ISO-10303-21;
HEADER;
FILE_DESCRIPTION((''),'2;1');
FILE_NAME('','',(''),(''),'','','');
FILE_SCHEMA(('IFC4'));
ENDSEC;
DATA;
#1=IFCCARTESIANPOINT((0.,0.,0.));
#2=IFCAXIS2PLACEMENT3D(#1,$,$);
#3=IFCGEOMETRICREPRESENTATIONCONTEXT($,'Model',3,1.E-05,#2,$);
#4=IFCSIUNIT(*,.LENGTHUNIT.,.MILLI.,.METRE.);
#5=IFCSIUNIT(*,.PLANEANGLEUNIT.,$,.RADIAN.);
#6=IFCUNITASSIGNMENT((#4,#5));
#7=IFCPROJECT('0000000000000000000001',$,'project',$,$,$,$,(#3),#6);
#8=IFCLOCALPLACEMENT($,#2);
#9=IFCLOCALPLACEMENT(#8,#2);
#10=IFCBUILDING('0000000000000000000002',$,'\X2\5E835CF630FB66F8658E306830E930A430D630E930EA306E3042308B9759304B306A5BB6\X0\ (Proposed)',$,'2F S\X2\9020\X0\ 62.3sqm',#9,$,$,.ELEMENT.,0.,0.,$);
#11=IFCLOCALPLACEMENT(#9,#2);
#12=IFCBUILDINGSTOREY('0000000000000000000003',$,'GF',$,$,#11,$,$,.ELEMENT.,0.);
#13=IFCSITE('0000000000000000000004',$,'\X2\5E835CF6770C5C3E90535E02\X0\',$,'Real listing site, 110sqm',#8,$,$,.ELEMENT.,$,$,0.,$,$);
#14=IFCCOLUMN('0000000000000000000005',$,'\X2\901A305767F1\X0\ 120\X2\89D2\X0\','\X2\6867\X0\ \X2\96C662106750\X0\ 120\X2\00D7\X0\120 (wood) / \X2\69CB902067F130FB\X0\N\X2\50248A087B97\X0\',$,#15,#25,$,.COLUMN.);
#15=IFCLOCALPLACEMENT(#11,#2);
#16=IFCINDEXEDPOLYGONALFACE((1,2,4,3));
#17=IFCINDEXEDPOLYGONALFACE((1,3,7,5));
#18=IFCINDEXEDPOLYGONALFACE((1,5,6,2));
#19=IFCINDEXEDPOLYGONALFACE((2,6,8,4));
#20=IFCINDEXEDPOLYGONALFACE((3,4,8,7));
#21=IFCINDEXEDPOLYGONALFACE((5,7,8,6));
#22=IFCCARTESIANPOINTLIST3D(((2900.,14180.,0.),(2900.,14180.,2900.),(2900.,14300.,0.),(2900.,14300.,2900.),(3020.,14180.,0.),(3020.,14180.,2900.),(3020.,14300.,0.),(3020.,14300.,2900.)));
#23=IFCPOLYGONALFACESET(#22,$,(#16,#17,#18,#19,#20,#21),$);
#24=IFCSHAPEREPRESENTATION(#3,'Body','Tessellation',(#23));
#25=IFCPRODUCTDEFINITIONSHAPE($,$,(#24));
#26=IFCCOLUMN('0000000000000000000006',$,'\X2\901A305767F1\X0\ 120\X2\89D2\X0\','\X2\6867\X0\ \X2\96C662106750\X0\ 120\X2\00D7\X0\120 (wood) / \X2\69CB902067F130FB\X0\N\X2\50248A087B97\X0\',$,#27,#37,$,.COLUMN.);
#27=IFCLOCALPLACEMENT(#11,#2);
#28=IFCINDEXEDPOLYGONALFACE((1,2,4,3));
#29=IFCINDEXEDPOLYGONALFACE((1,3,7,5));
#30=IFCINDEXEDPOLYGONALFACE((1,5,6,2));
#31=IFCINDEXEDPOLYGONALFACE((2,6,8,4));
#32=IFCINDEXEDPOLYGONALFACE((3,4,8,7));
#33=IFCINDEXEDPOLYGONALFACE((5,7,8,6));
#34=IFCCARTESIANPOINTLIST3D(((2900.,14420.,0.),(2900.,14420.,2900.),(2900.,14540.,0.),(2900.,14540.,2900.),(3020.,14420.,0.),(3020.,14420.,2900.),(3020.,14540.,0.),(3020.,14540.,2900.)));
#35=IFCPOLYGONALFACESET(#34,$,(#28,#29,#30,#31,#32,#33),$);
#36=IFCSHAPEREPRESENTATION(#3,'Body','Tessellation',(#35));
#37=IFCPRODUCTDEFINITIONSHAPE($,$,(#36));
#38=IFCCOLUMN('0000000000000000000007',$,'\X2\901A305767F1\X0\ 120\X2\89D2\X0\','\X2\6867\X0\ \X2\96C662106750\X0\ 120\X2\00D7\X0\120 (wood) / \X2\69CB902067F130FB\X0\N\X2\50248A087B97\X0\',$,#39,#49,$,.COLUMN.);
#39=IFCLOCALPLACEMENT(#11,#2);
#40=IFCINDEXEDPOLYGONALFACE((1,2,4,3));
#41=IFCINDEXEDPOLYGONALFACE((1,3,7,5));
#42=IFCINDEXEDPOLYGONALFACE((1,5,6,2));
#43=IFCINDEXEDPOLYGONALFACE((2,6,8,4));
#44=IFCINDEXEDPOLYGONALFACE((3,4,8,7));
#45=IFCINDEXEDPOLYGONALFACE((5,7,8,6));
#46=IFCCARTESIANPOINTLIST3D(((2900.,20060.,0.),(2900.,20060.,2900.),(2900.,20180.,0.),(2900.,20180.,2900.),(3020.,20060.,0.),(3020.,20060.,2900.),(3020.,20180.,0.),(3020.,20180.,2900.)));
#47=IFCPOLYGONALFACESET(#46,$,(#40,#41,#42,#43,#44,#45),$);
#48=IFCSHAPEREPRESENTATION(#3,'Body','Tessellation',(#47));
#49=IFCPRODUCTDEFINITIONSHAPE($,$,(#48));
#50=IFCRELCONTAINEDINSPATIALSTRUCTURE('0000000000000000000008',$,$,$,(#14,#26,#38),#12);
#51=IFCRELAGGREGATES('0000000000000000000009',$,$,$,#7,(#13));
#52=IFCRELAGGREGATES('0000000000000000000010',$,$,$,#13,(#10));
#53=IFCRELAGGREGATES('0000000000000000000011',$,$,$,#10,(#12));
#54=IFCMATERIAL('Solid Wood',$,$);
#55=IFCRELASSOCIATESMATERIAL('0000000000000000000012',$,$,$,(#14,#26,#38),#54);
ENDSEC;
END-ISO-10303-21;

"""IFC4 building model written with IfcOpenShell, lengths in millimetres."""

from ifc_helpers import new_model, si_unit, frame, frame_2d, origin, place, context, project, spatial, rectangle, extrude, material, element, save


model = new_model("IFC4")

# Units and contexts
model_context = context("Model", 3, precision=1e-05, world=origin())
ifc_project = project(units=[si_unit("LENGTHUNIT", "METRE", prefix="MILLI"), si_unit("PLANEANGLEUNIT", "RADIAN")], contexts=[model_context])

# Site, building, storey
site_placement = place(None, origin())
site = spatial("IfcSite", under=ifc_project, at=site_placement, Name="広島県尾道市", ObjectType="Real listing site, 110sqm", CompositionType="ELEMENT", RefElevation=0.0)
building_placement = place(site_placement, origin())
building = spatial("IfcBuilding", under=site, at=building_placement, Name="広島・書斎とライブラリのある静かな家 (Proposed)", ObjectType="2F S造 62.3sqm", CompositionType="ELEMENT", ElevationOfRefHeight=0.0, ElevationOfTerrain=0.0)
storey_placement = place(building_placement, origin())
storey = spatial("IfcBuildingStorey", under=building, at=storey_placement, Name="GF", CompositionType="ELEMENT", Elevation=0.0)

# Columns
ifc_material_1 = material(Name="Solid Wood")
column_1_placement = place(storey_placement, frame((1450.0, 7090.0, 0.0)))
element("IfcColumn", 1, at=column_1_placement, inside=storey, material=ifc_material_1, Name="通し柱 120角", Description="桧 集成材 120×120 (wood) / 構造柱・N値計算", PredefinedType="COLUMN", context=model_context, shape_type="SweptSolid", body=[
    extrude(rectangle(XDim=120.0, YDim=120.0, at=frame_2d((60.0, 60.0))), frame((1450.0, 7090.0, 0.0)), (0.0, 0.0, 1.0), 2900.0),
])
column_2_placement = place(storey_placement, frame((1450.0, 7210.0, 0.0)))
element("IfcColumn", 2, at=column_2_placement, inside=storey, material=ifc_material_1, Name="通し柱 120角", Description="桧 集成材 120×120 (wood) / 構造柱・N値計算", PredefinedType="COLUMN", context=model_context, shape_type="SweptSolid", body=[
    extrude(rectangle(XDim=120.0, YDim=120.0, at=frame_2d((60.0, 60.0))), frame((1450.0, 7210.0, 0.0)), (0.0, 0.0, 1.0), 2900.0),
])
column_3_placement = place(storey_placement, frame((1450.0, 10030.0, 0.0)))
element("IfcColumn", 3, at=column_3_placement, inside=storey, material=ifc_material_1, Name="通し柱 120角", Description="桧 集成材 120×120 (wood) / 構造柱・N値計算", PredefinedType="COLUMN", context=model_context, shape_type="SweptSolid", body=[
    extrude(rectangle(XDim=120.0, YDim=120.0, at=frame_2d((60.0, 60.0))), frame((1450.0, 10030.0, 0.0)), (0.0, 0.0, 1.0), 2900.0),
])

save(model, "model.ifc")
